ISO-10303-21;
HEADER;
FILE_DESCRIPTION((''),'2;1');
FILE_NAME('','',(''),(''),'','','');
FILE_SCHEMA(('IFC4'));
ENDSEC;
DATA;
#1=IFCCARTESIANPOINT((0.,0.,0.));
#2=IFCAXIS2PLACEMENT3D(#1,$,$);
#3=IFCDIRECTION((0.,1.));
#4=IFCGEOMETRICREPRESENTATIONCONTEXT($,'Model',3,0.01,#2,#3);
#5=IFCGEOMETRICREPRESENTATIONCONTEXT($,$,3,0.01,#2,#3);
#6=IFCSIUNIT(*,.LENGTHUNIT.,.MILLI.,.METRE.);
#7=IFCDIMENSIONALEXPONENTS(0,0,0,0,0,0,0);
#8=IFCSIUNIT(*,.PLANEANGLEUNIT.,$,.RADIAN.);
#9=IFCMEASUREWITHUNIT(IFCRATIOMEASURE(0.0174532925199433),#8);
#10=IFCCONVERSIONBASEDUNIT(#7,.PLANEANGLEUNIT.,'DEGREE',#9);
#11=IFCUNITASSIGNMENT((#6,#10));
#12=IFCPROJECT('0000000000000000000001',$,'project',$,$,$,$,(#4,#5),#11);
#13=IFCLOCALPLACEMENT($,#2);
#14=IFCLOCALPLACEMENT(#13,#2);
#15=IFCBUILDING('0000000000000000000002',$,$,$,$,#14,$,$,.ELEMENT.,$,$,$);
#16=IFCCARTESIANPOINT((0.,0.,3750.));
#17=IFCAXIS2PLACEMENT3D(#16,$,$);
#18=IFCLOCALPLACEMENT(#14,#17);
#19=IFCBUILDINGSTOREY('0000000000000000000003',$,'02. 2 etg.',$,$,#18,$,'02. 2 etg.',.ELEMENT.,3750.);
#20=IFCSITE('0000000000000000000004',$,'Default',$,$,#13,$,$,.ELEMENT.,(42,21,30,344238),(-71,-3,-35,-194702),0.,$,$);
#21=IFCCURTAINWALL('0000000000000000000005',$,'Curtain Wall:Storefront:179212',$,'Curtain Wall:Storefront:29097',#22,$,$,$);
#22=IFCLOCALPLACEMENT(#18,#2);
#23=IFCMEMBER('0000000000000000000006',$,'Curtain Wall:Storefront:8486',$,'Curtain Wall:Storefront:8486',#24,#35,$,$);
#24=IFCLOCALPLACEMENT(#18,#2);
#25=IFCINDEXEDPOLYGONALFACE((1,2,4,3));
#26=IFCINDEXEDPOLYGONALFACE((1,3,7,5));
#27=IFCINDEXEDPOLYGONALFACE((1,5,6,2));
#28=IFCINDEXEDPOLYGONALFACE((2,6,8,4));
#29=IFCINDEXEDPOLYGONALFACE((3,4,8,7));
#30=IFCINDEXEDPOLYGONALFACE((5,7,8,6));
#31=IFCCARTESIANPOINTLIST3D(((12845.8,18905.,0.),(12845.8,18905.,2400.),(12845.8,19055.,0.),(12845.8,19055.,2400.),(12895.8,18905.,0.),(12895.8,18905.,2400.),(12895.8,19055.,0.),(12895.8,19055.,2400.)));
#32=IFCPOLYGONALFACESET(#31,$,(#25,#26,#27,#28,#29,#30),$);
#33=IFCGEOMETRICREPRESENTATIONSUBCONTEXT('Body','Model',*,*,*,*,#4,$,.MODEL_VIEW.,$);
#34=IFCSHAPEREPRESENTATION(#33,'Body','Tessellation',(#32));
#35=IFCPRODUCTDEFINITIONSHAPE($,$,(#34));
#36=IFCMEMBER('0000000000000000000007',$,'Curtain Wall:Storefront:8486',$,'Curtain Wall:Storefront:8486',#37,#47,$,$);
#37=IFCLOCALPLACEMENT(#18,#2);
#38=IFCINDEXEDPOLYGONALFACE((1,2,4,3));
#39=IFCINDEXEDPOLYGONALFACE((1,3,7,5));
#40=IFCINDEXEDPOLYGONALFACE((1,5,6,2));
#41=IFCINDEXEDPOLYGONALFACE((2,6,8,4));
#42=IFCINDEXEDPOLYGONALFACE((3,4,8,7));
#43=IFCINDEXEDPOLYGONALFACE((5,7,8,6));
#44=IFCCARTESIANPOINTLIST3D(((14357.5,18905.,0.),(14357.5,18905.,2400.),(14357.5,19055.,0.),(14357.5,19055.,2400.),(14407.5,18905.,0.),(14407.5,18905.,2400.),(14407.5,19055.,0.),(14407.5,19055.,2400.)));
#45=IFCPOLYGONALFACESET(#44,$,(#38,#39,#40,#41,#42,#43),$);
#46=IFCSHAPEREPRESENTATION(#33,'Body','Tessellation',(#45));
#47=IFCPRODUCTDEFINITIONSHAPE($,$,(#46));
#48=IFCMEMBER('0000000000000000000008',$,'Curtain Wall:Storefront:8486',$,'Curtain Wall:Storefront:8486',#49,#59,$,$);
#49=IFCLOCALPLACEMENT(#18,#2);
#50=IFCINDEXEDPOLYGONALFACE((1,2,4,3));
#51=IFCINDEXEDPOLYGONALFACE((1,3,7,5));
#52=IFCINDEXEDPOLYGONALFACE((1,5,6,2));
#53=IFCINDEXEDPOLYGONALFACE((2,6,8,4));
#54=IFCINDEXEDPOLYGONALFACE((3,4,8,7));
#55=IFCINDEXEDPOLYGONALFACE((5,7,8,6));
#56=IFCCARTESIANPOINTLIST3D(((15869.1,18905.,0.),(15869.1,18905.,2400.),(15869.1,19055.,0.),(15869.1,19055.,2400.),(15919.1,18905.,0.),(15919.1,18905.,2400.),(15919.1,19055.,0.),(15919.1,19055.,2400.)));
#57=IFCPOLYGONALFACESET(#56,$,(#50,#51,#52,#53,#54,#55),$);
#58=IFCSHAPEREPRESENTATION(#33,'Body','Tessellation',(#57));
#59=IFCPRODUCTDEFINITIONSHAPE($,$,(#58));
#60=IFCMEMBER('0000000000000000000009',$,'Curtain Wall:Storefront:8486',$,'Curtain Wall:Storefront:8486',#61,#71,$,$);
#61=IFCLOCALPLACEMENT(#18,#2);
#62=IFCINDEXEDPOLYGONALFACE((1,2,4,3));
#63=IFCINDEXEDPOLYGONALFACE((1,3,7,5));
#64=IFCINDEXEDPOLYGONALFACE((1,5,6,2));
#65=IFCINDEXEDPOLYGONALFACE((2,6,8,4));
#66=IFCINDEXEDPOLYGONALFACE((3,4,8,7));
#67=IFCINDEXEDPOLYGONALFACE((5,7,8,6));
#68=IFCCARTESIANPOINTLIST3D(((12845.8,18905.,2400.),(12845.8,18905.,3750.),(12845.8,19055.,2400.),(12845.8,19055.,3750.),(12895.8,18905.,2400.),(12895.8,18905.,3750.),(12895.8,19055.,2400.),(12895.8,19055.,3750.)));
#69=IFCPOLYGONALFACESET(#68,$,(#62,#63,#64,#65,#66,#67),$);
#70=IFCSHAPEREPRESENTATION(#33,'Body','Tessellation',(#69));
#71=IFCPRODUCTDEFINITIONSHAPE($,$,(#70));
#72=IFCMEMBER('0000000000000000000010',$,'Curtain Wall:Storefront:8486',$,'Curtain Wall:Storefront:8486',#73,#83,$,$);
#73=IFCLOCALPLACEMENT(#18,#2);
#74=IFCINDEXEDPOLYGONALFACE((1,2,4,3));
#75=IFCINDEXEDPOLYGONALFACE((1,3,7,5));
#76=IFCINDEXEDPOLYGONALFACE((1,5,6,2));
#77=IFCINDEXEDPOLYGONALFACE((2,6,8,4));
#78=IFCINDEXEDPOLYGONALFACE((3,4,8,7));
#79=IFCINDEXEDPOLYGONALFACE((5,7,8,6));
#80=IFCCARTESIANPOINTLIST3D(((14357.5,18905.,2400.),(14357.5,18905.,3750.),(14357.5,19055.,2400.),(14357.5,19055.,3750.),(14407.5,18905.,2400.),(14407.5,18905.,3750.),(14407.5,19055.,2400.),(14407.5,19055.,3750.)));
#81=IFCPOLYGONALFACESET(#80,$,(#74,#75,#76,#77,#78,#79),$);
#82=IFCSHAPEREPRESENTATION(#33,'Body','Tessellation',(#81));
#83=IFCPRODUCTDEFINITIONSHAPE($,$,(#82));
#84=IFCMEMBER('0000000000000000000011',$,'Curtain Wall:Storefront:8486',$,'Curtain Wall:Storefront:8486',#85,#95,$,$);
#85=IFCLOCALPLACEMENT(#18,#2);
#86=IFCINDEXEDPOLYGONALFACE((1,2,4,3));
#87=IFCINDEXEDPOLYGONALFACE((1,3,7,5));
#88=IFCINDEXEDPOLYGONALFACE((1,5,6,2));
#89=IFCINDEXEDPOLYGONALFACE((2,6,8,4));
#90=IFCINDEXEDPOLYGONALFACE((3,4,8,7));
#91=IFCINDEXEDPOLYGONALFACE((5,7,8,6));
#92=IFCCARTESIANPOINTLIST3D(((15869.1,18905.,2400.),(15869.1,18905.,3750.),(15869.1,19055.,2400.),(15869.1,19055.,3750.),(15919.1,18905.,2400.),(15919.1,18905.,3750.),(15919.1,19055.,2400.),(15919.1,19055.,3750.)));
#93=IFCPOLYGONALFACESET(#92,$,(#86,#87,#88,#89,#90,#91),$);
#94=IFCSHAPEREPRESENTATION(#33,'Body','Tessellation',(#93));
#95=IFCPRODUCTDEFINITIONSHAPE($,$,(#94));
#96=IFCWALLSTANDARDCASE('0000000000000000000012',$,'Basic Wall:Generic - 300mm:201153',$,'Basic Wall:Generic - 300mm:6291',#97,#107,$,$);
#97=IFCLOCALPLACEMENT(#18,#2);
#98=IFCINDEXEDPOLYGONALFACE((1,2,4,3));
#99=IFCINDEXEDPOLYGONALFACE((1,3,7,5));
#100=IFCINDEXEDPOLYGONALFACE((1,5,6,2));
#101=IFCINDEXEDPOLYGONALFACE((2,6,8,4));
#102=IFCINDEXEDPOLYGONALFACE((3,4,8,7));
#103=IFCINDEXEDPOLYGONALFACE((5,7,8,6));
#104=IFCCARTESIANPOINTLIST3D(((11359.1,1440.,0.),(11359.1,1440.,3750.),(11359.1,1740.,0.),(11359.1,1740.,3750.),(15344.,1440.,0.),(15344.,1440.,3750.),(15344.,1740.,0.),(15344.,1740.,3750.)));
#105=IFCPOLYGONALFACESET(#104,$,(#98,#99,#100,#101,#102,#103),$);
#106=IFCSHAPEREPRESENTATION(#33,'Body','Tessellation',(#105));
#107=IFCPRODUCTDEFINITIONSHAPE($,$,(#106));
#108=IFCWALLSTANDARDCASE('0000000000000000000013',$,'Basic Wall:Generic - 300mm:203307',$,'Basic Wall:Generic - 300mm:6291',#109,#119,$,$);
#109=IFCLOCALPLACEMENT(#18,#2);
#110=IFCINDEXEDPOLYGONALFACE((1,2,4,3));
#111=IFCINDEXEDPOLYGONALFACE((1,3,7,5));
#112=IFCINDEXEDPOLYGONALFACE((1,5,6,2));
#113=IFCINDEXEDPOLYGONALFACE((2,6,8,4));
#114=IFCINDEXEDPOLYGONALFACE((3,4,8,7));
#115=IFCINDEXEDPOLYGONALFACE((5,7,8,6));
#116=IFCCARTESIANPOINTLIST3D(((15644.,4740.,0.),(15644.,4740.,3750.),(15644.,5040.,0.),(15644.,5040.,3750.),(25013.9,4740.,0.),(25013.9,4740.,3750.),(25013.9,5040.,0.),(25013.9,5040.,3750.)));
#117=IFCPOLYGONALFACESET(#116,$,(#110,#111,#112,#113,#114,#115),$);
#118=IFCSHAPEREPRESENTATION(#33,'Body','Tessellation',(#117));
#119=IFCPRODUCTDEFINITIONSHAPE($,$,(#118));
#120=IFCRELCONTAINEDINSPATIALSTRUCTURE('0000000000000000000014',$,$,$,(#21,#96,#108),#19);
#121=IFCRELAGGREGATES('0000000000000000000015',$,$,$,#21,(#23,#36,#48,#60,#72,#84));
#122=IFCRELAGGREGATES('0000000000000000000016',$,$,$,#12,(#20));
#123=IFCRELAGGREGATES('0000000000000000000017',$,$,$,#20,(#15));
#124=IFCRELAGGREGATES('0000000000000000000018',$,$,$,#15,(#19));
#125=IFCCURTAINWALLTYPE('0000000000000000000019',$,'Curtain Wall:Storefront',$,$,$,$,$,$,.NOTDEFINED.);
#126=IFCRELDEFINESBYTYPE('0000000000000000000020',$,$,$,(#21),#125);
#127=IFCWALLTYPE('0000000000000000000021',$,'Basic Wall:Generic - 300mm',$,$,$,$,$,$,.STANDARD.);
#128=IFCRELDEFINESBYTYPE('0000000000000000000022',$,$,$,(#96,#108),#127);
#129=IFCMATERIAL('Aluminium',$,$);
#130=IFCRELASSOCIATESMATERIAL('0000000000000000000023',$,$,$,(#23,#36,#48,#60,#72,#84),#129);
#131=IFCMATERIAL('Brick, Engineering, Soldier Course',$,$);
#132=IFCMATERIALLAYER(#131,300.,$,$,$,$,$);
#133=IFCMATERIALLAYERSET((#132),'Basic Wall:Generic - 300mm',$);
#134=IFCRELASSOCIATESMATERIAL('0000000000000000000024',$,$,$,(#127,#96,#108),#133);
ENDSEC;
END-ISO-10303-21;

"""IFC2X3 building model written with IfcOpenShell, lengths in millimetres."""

from ifc_helpers import new_model, entity, si_unit, converted_unit, direction, frame, frame_2d, origin, place, context, subcontext, project, spatial, rectangle, extrude, clip, halfspace, material, layer, layer_set, layer_usage, type_object, element, aggregate, save


model = new_model("IFC2X3")

# Units and contexts
model_context = context("Model", 3, precision=0.01, world=origin(), true_north=direction((0.0, 1.0)))
context_of_model = context(None, 3, precision=0.01, world=origin(), true_north=direction((0.0, 1.0)))
body_context = subcontext(model_context, "Body", "Model", "MODEL_VIEW")
ifc_project = project(units=[si_unit("LENGTHUNIT", "METRE", prefix="MILLI"), converted_unit("PLANEANGLEUNIT", "DEGREE", entity("IfcRatioMeasure", 0.0174532925199433), si_unit("PLANEANGLEUNIT", "RADIAN"), dimensions=[0, 0, 0, 0, 0, 0, 0])], contexts=[model_context, context_of_model])

# Site, building, storey
site_placement = place(None, origin())
site = spatial("IfcSite", under=ifc_project, at=site_placement, Name="Default", CompositionType="ELEMENT", RefLatitude=(42, 21, 30, 344238), RefLongitude=(-71, -3, -35, -194702), RefElevation=0.0)
building_placement = place(site_placement, origin())
building = spatial("IfcBuilding", under=site, at=building_placement, CompositionType="ELEMENT")
storey_placement = place(building_placement, frame((0.0, 0.0, 3750.0)))
storey = spatial("IfcBuildingStorey", under=building, at=storey_placement, Name="02. 2 etg.", LongName="02. 2 etg.", CompositionType="ELEMENT", Elevation=3750.0)

# Curtain wall, members
curtain_wall_type = type_object("IfcCurtainWallType", Name="Curtain Wall:Storefront", PredefinedType="NOTDEFINED")
curtain_wall_placement = place(storey_placement, frame((0.0, 0.0, -3750.0)))
curtain_wall = element("IfcCurtainWall", 1, at=curtain_wall_placement, inside=storey, type_object=curtain_wall_type, Name="Curtain Wall:Storefront:179212", ObjectType="Curtain Wall:Storefront:29097")
ifc_material_1 = material(Name="Aluminium")
member_1_placement = place(curtain_wall_placement, frame((12845.8, 18905.0, 3750.0)))
member_1 = element("IfcMember", 2, at=member_1_placement, material=ifc_material_1, Name="Curtain Wall:Storefront:8486", ObjectType="Curtain Wall:Storefront:8486", context=body_context, shape_type="SweptSolid", body=[
    extrude(rectangle(XDim=150.0, YDim=50.0, at=frame_2d((0.0, 0.0), x_axis=(1.0, 0.0))), frame((25.0, 75.0, 0.0), z_axis=(0.0, 0.0, 1.0), x_axis=(0.0, 1.0, 0.0)), (0.0, 0.0, 1.0), 2400.0),
])
member_2_placement = place(curtain_wall_placement, frame((14357.5, 18905.0, 3750.0)))
member_2 = element("IfcMember", 3, at=member_2_placement, material=ifc_material_1, Name="Curtain Wall:Storefront:8486", ObjectType="Curtain Wall:Storefront:8486", context=body_context, shape_type="SweptSolid", body=[
    extrude(rectangle(XDim=150.0, YDim=50.0, at=frame_2d((0.0, 0.0), x_axis=(1.0, 0.0))), frame((25.0, 75.0, 0.0), z_axis=(0.0, 0.0, 1.0), x_axis=(0.0, 1.0, 0.0)), (0.0, 0.0, 1.0), 2400.0),
])
member_3_placement = place(curtain_wall_placement, frame((15869.1, 18905.0, 3750.0)))
member_3 = element("IfcMember", 4, at=member_3_placement, material=ifc_material_1, Name="Curtain Wall:Storefront:8486", ObjectType="Curtain Wall:Storefront:8486", context=body_context, shape_type="SweptSolid", body=[
    extrude(rectangle(XDim=150.0, YDim=50.0, at=frame_2d((0.0, 0.0), x_axis=(1.0, 0.0))), frame((25.0, 75.0, 0.0), z_axis=(0.0, 0.0, 1.0), x_axis=(0.0, 1.0, 0.0)), (0.0, 0.0, 1.0), 2400.0),
])
member_4_placement = place(curtain_wall_placement, frame((12845.8, 18905.0, 6150.0)))
member_4 = element("IfcMember", 5, at=member_4_placement, material=ifc_material_1, Name="Curtain Wall:Storefront:8486", ObjectType="Curtain Wall:Storefront:8486", context=body_context, shape_type="SweptSolid", body=[
    extrude(rectangle(XDim=150.0, YDim=50.0, at=frame_2d((0.0, 0.0), x_axis=(1.0, 0.0))), frame((25.0, 75.0, 0.0), z_axis=(0.0, 0.0, 1.0), x_axis=(0.0, 1.0, 0.0)), (0.0, 0.0, 1.0), 1350.0),
])
member_5_placement = place(curtain_wall_placement, frame((14357.5, 18905.0, 6150.0)))
member_5 = element("IfcMember", 6, at=member_5_placement, material=ifc_material_1, Name="Curtain Wall:Storefront:8486", ObjectType="Curtain Wall:Storefront:8486", context=body_context, shape_type="SweptSolid", body=[
    extrude(rectangle(XDim=150.0, YDim=50.0, at=frame_2d((0.0, 0.0), x_axis=(1.0, 0.0))), frame((25.0, 75.0, 0.0), z_axis=(0.0, 0.0, 1.0), x_axis=(0.0, 1.0, 0.0)), (0.0, 0.0, 1.0), 1350.0),
])
member_6_placement = place(curtain_wall_placement, frame((15869.1, 18905.0, 6150.0)))
member_6 = element("IfcMember", 7, at=member_6_placement, material=ifc_material_1, Name="Curtain Wall:Storefront:8486", ObjectType="Curtain Wall:Storefront:8486", context=body_context, shape_type="SweptSolid", body=[
    extrude(rectangle(XDim=150.0, YDim=50.0, at=frame_2d((0.0, 0.0), x_axis=(1.0, 0.0))), frame((25.0, 75.0, 0.0), z_axis=(0.0, 0.0, 1.0), x_axis=(0.0, 1.0, 0.0)), (0.0, 0.0, 1.0), 1350.0),
])
aggregate(curtain_wall, [member_1, member_2, member_3, member_4, member_5, member_6])

# Walls
ifc_material_2 = material(Name="Brick, Engineering, Soldier Course")
ifc_layer = layer(ifc_material_2, 300.0)
ifc_layer_set = layer_set([ifc_layer], Name="Basic Wall:Generic - 300mm")
ifc_layer_usage_1 = layer_usage(ifc_layer_set, "AXIS2", "NEGATIVE", 150.0)
wall_type = type_object("IfcWallType", Name="Basic Wall:Generic - 300mm", PredefinedType="STANDARD", material=ifc_layer_set)
wall_1_placement = place(storey_placement, frame((15344.0, 1590.0, 0.0), z_axis=(0.0, 0.0, 1.0), x_axis=(-1.0, 0.0, 0.0)))
element("IfcWallStandardCase", 8, at=wall_1_placement, inside=storey, type_object=wall_type, material=ifc_layer_usage_1, Name="Basic Wall:Generic - 300mm:201153", ObjectType="Basic Wall:Generic - 300mm:6291", context=body_context, shape_type="SweptSolid", body=[
    extrude(rectangle(XDim=3984.9, YDim=300.0, at=frame_2d((1992.4, 0.0), x_axis=(-1.0, 0.0))), origin(), (0.0, 0.0, 1.0), 3750.0),
])
ifc_layer_usage_2 = layer_usage(ifc_layer_set, "AXIS2", "NEGATIVE", 150.0)
wall_2_placement = place(storey_placement, frame((15644.0, 4890.0, 0.0)))
element("IfcWallStandardCase", 9, at=wall_2_placement, inside=storey, type_object=wall_type, material=ifc_layer_usage_2, Name="Basic Wall:Generic - 300mm:203307", ObjectType="Basic Wall:Generic - 300mm:6291", context=body_context, shape_type="Clipping", body=[
    clip(extrude(rectangle(XDim=9369.9, YDim=300.0, at=frame_2d((4684.9, 0.0), x_axis=(-1.0, 0.0))), origin(), (0.0, 0.0, 1.0), 3750.0), halfspace(origin(), True)),
])

save(model, "model.ifc")
